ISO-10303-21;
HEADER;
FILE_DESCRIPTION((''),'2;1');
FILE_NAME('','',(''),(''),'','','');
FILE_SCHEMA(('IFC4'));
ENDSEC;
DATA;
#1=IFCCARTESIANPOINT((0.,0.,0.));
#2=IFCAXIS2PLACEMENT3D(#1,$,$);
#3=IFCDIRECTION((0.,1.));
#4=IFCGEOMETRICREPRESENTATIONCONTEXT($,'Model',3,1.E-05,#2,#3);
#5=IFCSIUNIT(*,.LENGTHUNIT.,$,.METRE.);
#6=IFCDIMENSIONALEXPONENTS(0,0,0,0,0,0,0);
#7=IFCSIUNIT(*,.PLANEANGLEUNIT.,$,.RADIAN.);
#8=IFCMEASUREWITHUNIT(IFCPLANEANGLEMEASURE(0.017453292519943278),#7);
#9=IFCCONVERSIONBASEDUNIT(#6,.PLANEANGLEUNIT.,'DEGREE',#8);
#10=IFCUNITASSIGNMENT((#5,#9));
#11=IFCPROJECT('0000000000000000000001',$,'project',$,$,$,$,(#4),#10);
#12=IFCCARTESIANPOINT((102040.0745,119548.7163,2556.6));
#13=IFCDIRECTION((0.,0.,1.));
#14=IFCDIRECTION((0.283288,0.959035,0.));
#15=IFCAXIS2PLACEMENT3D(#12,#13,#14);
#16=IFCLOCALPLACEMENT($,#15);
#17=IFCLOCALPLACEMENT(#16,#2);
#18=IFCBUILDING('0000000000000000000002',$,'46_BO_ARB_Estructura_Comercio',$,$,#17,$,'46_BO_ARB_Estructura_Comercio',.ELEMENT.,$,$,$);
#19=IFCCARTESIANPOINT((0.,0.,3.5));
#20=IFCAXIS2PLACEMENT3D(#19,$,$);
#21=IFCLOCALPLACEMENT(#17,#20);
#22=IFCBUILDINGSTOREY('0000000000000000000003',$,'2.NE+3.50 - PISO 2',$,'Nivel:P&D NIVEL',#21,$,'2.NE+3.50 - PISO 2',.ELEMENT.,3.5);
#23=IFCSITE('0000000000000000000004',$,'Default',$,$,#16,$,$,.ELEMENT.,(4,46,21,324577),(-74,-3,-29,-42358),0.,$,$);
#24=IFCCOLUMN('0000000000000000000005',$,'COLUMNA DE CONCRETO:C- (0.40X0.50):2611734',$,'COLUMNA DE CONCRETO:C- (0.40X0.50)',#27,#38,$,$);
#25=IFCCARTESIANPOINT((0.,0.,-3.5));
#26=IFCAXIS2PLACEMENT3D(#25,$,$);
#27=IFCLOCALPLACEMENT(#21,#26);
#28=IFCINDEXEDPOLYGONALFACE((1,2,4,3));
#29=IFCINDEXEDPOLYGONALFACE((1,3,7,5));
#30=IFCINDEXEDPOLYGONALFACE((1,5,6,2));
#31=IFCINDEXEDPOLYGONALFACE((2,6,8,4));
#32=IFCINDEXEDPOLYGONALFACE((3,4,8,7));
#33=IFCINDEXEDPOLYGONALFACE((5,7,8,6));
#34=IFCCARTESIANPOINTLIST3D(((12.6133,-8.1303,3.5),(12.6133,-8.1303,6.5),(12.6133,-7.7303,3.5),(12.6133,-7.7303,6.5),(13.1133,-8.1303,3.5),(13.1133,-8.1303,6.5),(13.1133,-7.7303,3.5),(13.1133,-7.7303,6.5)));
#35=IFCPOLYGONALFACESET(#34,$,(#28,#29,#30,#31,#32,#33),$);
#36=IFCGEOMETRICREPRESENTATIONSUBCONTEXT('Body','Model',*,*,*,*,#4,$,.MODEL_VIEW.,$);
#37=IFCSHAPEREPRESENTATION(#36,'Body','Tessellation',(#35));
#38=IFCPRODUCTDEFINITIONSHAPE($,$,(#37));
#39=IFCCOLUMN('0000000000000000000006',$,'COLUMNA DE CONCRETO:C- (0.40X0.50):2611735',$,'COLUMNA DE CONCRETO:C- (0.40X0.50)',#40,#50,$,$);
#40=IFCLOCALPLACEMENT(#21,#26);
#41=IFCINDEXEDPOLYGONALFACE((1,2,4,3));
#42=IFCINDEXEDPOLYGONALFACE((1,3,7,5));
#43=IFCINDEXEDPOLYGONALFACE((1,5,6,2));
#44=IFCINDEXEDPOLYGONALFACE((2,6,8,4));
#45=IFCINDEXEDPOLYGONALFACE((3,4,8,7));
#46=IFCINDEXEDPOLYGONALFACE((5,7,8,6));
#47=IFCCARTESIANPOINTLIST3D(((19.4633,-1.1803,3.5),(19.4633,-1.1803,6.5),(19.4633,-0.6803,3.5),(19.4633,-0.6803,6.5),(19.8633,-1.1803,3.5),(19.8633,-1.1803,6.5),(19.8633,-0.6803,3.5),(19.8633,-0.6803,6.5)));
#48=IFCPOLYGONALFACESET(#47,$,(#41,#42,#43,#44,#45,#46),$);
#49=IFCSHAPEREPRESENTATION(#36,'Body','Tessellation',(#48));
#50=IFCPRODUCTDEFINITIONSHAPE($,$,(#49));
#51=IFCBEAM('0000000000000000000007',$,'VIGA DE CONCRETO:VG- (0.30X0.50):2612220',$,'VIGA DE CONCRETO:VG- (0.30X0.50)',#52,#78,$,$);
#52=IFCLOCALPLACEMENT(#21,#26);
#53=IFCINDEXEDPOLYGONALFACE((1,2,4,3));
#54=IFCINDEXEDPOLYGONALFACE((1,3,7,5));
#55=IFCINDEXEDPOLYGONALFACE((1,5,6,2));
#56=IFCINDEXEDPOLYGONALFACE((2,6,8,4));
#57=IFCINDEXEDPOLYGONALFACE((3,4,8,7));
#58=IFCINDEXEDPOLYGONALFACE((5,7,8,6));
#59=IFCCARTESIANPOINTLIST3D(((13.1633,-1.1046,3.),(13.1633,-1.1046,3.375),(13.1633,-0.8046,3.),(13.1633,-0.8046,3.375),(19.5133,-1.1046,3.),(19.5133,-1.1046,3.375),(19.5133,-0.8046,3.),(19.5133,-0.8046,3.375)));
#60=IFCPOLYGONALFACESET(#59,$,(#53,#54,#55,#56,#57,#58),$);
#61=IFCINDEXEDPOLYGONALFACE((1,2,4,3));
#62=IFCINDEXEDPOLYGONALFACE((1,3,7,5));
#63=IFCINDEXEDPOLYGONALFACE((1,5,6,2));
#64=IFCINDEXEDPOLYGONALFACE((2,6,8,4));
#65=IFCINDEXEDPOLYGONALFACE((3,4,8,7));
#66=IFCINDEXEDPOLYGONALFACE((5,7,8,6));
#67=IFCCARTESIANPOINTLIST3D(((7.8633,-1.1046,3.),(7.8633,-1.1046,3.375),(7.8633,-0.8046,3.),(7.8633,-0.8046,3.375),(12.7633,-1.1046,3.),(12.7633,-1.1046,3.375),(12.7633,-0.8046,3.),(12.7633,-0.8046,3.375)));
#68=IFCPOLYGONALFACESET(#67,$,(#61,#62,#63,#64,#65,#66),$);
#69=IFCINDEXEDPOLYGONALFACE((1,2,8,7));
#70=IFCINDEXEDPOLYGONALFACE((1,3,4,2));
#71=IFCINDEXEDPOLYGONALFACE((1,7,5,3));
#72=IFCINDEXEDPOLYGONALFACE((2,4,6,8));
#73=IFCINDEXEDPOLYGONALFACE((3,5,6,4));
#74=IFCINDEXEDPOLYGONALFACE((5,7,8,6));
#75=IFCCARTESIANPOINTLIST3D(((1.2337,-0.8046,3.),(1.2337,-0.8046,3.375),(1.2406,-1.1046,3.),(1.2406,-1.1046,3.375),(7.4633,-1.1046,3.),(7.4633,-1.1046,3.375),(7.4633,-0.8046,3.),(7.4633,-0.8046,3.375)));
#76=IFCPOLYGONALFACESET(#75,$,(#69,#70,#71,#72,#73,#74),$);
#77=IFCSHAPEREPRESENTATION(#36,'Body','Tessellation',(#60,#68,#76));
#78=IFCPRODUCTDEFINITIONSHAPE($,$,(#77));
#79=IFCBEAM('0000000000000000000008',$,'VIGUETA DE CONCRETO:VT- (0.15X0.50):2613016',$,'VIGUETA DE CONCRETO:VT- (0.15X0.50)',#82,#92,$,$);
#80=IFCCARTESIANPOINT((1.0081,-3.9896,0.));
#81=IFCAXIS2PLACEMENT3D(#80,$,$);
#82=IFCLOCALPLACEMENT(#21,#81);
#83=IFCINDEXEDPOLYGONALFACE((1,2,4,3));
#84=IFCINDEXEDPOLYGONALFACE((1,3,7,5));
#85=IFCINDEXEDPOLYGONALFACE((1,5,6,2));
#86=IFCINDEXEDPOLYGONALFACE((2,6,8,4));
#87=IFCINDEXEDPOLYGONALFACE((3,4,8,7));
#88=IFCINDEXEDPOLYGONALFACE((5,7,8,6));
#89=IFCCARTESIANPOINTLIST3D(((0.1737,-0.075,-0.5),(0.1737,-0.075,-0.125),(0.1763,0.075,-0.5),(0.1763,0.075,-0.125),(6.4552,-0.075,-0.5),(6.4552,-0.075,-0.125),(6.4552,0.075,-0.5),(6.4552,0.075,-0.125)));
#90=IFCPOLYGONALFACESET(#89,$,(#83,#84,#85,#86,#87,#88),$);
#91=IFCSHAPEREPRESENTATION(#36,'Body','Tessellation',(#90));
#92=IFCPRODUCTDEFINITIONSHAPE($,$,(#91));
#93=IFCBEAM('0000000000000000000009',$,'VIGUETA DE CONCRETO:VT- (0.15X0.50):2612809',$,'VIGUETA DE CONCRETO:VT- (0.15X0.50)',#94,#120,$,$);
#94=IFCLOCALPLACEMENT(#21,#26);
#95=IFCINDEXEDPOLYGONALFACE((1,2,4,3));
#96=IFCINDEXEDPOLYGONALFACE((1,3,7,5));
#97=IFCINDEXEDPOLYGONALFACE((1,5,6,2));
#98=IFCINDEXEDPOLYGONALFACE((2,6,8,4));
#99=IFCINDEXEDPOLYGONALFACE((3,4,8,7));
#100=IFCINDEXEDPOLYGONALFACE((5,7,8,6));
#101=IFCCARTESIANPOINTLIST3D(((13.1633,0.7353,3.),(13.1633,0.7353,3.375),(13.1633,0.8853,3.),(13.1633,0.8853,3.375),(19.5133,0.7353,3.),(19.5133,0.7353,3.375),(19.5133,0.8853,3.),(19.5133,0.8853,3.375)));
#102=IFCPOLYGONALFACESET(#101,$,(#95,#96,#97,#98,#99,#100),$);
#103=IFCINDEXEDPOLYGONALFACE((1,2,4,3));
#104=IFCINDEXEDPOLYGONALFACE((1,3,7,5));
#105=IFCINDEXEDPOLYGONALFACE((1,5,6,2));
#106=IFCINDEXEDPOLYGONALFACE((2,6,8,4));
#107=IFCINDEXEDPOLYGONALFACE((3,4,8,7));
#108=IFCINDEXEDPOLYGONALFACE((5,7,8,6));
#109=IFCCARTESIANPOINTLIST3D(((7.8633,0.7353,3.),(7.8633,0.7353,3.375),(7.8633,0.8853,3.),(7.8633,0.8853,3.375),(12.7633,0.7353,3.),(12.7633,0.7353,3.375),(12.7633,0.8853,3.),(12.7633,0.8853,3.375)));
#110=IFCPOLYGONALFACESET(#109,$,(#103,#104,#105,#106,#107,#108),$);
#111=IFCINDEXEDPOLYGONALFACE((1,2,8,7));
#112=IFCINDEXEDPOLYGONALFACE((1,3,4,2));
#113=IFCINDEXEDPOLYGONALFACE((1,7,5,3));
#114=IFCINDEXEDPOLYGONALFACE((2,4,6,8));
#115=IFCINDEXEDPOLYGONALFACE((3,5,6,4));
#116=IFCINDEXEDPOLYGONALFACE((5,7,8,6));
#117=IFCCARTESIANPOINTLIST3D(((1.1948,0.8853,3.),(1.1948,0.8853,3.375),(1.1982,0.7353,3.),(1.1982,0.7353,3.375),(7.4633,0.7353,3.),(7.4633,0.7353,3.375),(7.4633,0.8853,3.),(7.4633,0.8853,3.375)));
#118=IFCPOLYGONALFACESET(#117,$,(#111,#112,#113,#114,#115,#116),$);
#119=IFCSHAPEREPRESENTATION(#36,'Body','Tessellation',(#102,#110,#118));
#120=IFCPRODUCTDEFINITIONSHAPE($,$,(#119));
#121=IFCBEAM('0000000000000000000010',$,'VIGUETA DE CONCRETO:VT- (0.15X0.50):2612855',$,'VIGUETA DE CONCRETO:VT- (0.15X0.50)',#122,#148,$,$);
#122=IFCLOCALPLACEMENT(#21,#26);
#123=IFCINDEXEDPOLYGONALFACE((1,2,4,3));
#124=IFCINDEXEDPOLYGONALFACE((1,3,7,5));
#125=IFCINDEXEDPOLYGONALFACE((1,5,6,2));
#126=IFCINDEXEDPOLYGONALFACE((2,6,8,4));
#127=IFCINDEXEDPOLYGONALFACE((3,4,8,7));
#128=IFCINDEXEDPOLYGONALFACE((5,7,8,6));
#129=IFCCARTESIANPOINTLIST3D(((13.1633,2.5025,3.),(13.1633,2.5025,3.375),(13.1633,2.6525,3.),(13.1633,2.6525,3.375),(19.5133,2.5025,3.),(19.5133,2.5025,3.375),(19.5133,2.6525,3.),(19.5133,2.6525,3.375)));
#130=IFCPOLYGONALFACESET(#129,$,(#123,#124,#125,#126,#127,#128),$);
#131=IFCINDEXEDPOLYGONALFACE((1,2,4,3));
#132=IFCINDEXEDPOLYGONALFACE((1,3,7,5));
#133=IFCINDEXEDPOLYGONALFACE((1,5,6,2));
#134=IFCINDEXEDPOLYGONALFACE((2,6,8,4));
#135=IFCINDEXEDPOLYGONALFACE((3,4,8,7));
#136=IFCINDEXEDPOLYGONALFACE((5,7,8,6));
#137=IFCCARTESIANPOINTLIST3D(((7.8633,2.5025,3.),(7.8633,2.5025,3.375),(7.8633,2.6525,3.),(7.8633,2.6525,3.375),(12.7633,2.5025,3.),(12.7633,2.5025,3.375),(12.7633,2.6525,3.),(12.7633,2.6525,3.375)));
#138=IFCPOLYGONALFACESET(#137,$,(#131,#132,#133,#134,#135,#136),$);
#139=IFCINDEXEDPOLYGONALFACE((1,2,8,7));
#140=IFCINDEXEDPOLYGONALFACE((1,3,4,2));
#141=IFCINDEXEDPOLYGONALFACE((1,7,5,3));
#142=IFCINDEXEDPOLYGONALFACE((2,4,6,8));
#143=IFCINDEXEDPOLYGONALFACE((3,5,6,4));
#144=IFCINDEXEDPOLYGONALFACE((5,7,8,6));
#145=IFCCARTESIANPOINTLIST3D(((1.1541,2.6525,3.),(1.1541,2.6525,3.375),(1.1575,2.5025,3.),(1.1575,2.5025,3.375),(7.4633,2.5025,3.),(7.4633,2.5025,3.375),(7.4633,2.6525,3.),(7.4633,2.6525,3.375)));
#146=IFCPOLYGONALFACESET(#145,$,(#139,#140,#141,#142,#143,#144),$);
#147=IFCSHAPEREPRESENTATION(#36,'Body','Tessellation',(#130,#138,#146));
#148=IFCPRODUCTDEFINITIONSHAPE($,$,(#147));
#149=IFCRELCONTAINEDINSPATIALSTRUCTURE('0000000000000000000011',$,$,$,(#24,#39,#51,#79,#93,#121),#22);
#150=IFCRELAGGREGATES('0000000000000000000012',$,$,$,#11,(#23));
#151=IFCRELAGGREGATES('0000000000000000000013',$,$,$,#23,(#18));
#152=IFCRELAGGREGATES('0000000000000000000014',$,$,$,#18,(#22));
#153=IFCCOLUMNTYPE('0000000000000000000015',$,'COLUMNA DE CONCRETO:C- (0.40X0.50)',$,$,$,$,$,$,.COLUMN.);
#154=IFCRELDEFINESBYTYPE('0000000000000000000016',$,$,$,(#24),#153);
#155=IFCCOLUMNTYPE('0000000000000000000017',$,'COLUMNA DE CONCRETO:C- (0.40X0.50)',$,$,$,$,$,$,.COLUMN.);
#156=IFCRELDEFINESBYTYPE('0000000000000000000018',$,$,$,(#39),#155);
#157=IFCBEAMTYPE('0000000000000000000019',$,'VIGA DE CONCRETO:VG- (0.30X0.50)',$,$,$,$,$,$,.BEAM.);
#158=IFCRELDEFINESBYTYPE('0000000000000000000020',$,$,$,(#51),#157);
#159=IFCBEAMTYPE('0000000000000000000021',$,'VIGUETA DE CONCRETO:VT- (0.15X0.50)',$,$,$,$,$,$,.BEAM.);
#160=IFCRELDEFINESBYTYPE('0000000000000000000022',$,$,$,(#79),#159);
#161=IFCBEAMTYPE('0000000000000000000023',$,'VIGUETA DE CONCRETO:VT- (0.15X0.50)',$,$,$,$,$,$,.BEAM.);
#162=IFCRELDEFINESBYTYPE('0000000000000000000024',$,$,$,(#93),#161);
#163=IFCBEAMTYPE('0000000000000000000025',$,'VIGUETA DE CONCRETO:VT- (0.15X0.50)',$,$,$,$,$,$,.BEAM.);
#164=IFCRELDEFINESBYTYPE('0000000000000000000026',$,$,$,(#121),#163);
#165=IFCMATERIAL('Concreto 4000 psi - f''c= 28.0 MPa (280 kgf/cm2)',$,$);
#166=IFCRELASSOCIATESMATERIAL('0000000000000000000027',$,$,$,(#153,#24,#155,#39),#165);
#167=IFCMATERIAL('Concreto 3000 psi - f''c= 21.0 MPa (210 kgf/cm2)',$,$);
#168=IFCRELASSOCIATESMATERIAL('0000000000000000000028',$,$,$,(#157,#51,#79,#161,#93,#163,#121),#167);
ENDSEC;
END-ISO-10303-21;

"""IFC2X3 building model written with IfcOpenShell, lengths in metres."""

from ifc_helpers import new_model, entity, si_unit, converted_unit, direction, frame, frame_2d, origin, place, context, subcontext, project, spatial, rectangle, extrude, clip, halfspace, source, transform, mapped, material, type_object, type_shapes, element, save


model = new_model("IFC2X3")

# Units and contexts
model_context = context("Model", 3, precision=1e-05, world=origin(), true_north=direction((0.0, 1.0)))
body_context = subcontext(model_context, "Body", "Model", "MODEL_VIEW")
ifc_project = project(units=[si_unit("LENGTHUNIT", "METRE"), converted_unit("PLANEANGLEUNIT", "DEGREE", entity("IfcPlaneAngleMeasure", 0.017453292519943278), si_unit("PLANEANGLEUNIT", "RADIAN"), dimensions=[0, 0, 0, 0, 0, 0, 0])], contexts=[model_context])

# Site, building, storey
site_placement = place(None, frame((102040.0745, 119548.7163, 2556.6), z_axis=(0.0, 0.0, 1.0), x_axis=(0.283288, 0.959035, 0.0)))
site = spatial("IfcSite", under=ifc_project, at=site_placement, Name="Default", CompositionType="ELEMENT", RefLatitude=(4, 46, 21, 324577), RefLongitude=(-74, -3, -29, -42358), RefElevation=0.0)
building_placement = place(site_placement, origin())
building = spatial("IfcBuilding", under=site, at=building_placement, Name="46_BO_ARB_Estructura_Comercio", LongName="46_BO_ARB_Estructura_Comercio", CompositionType="ELEMENT")
storey_placement = place(building_placement, frame((0.0, 0.0, 3.5)))
storey = spatial("IfcBuildingStorey", under=building, at=storey_placement, Name="2.NE+3.50 - PISO 2", ObjectType="Nivel:P&D NIVEL", LongName="2.NE+3.50 - PISO 2", CompositionType="ELEMENT", Elevation=3.5)

# Columns
ifc_material_1 = material(Name="Concreto 4000 psi - f'c= 28.0 MPa (280 kgf/cm2)")
column_type_1 = type_object("IfcColumnType", Name="COLUMNA DE CONCRETO:C- (0.40X0.50)", PredefinedType="COLUMN", material=ifc_material_1)
shared_shape_1 = source(origin(), body_context, "Body", "SweptSolid", [
    extrude(rectangle(XDim=0.4, YDim=0.5, at=frame_2d((0.0, 0.0), x_axis=(1.0, 0.0))), frame((12.8633, -7.9303, 3.5), z_axis=(0.0, 0.0, 1.0), x_axis=(0.0, -1.0, 0.0)), (0.0, 0.0, 1.0), 3.0),
])
type_shapes(column_type_1, [shared_shape_1])
column_1_placement = place(storey_placement, frame((0.0, 0.0, -3.5)))
element("IfcColumn", 1, at=column_1_placement, inside=storey, type_object=column_type_1, material=ifc_material_1, Name="COLUMNA DE CONCRETO:C- (0.40X0.50):2611734", ObjectType="COLUMNA DE CONCRETO:C- (0.40X0.50)", context=body_context, shape_type="MappedRepresentation", body=[
    mapped(shared_shape_1, transform((0.0, 0.0, 0.0), scale=1.0)),
])
column_type_2 = type_object("IfcColumnType", Name="COLUMNA DE CONCRETO:C- (0.40X0.50)", PredefinedType="COLUMN", material=ifc_material_1)
shared_shape_2 = source(origin(), body_context, "Body", "SweptSolid", [
    extrude(rectangle(XDim=0.5, YDim=0.4, at=frame_2d((0.0, 0.0), x_axis=(1.0, 0.0))), frame((19.6633, -0.9303, 3.5), z_axis=(0.0, 0.0, 1.0), x_axis=(0.0, -1.0, 0.0)), (0.0, 0.0, 1.0), 3.0),
])
type_shapes(column_type_2, [shared_shape_2])
column_2_placement = place(storey_placement, frame((0.0, 0.0, -3.5)))
element("IfcColumn", 2, at=column_2_placement, inside=storey, type_object=column_type_2, material=ifc_material_1, Name="COLUMNA DE CONCRETO:C- (0.40X0.50):2611735", ObjectType="COLUMNA DE CONCRETO:C- (0.40X0.50)", context=body_context, shape_type="MappedRepresentation", body=[
    mapped(shared_shape_2, transform((0.0, 0.0, 0.0), scale=1.0)),
])

# Beams
ifc_material_2 = material(Name="Concreto 3000 psi - f'c= 21.0 MPa (210 kgf/cm2)")
beam_type_1 = type_object("IfcBeamType", Name="VIGA DE CONCRETO:VG- (0.30X0.50)", PredefinedType="BEAM", material=ifc_material_2)
shared_shape_3 = source(origin(), body_context, "Body", "SweptSolid", [
    extrude(rectangle(XDim=0.375, YDim=0.3, at=frame_2d((0.0, 0.0), x_axis=(1.0, 0.0))), frame((13.1633, -0.9546, 3.1875), z_axis=(1.0, 0.0, 0.0), x_axis=(0.0, 0.0, -1.0)), (0.0, 0.0, 1.0), 6.35),
    extrude(rectangle(XDim=0.375, YDim=0.3, at=frame_2d((0.0, 0.0), x_axis=(1.0, 0.0))), frame((7.8633, -0.9546, 3.1875), z_axis=(1.0, 0.0, 0.0), x_axis=(0.0, 0.0, -1.0)), (0.0, 0.0, 1.0), 4.9),
    clip(extrude(rectangle(XDim=0.375, YDim=0.3, at=frame_2d((0.0, 0.0), x_axis=(1.0, 0.0))), frame((1.2337, -0.9546, 3.1875), z_axis=(1.0, 0.0, 0.0), x_axis=(0.0, 0.0, -1.0)), (0.0, 0.0, 1.0), 6.2296), halfspace(frame((1.1171, 4.257, 3.5), z_axis=(-0.999735, -0.023028, 0.0), x_axis=(0.023028, -0.999735, 0.0)), False)),
])
type_shapes(beam_type_1, [shared_shape_3])
beam_1_placement = place(storey_placement, frame((0.0, 0.0, -3.5)))
element("IfcBeam", 3, at=beam_1_placement, inside=storey, type_object=beam_type_1, material=ifc_material_2, Name="VIGA DE CONCRETO:VG- (0.30X0.50):2612220", ObjectType="VIGA DE CONCRETO:VG- (0.30X0.50)", context=body_context, shape_type="MappedRepresentation", body=[
    mapped(shared_shape_3, transform((0.0, 0.0, 0.0), scale=1.0)),
])
beam_type_2 = type_object("IfcBeamType", Name="VIGUETA DE CONCRETO:VT- (0.15X0.50)", PredefinedType="BEAM")
beam_2_placement = place(storey_placement, frame((1.0081, -3.9896, 0.0)))
element("IfcBeam", 4, at=beam_2_placement, inside=storey, type_object=beam_type_2, material=ifc_material_2, Name="VIGUETA DE CONCRETO:VT- (0.15X0.50):2613016", ObjectType="VIGUETA DE CONCRETO:VT- (0.15X0.50)", context=body_context, shape_type="SweptSolid", body=[
    clip(extrude(rectangle(XDim=0.375, YDim=0.15, at=frame_2d((0.0, 0.0), x_axis=(1.0, 0.0))), frame((0.1737, 0.0, -0.3125), z_axis=(1.0, 0.0, 0.0), x_axis=(0.0, 0.0, -1.0)), (0.0, 0.0, 1.0), 6.2815), halfspace(frame((0.2277, 3.0122, 0.0), z_axis=(-0.999847, 0.017477, 0.0), x_axis=(-0.017477, -0.999847, 0.0)), False)),
])
beam_type_3 = type_object("IfcBeamType", Name="VIGUETA DE CONCRETO:VT- (0.15X0.50)", PredefinedType="BEAM", material=ifc_material_2)
shared_shape_4 = source(origin(), body_context, "Body", "SweptSolid", [
    extrude(rectangle(XDim=0.375, YDim=0.15, at=frame_2d((0.0, 0.0), x_axis=(1.0, 0.0))), frame((13.1633, 0.8103, 3.1875), z_axis=(1.0, 0.0, 0.0), x_axis=(0.0, 0.0, -1.0)), (0.0, 0.0, 1.0), 6.35),
    extrude(rectangle(XDim=0.375, YDim=0.15, at=frame_2d((0.0, 0.0), x_axis=(1.0, 0.0))), frame((7.8633, 0.8103, 3.1875), z_axis=(1.0, 0.0, 0.0), x_axis=(0.0, 0.0, -1.0)), (0.0, 0.0, 1.0), 4.9),
    clip(extrude(rectangle(XDim=0.375, YDim=0.15, at=frame_2d((0.0, 0.0), x_axis=(1.0, 0.0))), frame((1.1948, 0.8103, 3.1875), z_axis=(1.0, 0.0, 0.0), x_axis=(0.0, 0.0, -1.0)), (0.0, 0.0, 1.0), 6.2685), halfspace(frame((1.1171, 4.257, 3.5), z_axis=(-0.999735, -0.023028, 0.0), x_axis=(0.023028, -0.999735, 0.0)), False)),
])
type_shapes(beam_type_3, [shared_shape_4])
beam_3_placement = place(storey_placement, frame((0.0, 0.0, -3.5)))
element("IfcBeam", 5, at=beam_3_placement, inside=storey, type_object=beam_type_3, material=ifc_material_2, Name="VIGUETA DE CONCRETO:VT- (0.15X0.50):2612809", ObjectType="VIGUETA DE CONCRETO:VT- (0.15X0.50)", context=body_context, shape_type="MappedRepresentation", body=[
    mapped(shared_shape_4, transform((0.0, 0.0, 0.0), scale=1.0)),
])
beam_type_4 = type_object("IfcBeamType", Name="VIGUETA DE CONCRETO:VT- (0.15X0.50)", PredefinedType="BEAM", material=ifc_material_2)
shared_shape_5 = source(origin(), body_context, "Body", "SweptSolid", [
    extrude(rectangle(XDim=0.375, YDim=0.15, at=frame_2d((0.0, 0.0), x_axis=(1.0, 0.0))), frame((13.1633, 2.5775, 3.1875), z_axis=(1.0, 0.0, 0.0), x_axis=(0.0, 0.0, -1.0)), (0.0, 0.0, 1.0), 6.35),
    extrude(rectangle(XDim=0.375, YDim=0.15, at=frame_2d((0.0, 0.0), x_axis=(1.0, 0.0))), frame((7.8633, 2.5775, 3.1875), z_axis=(1.0, 0.0, 0.0), x_axis=(0.0, 0.0, -1.0)), (0.0, 0.0, 1.0), 4.9),
    clip(extrude(rectangle(XDim=0.375, YDim=0.15, at=frame_2d((0.0, 0.0), x_axis=(1.0, 0.0))), frame((1.1541, 2.5775, 3.1875), z_axis=(1.0, 0.0, 0.0), x_axis=(0.0, 0.0, -1.0)), (0.0, 0.0, 1.0), 6.3092), halfspace(frame((1.1171, 4.257, 3.5), z_axis=(-0.999735, -0.023028, 0.0), x_axis=(0.023028, -0.999735, 0.0)), False)),
])
type_shapes(beam_type_4, [shared_shape_5])
beam_4_placement = place(storey_placement, frame((0.0, 0.0, -3.5)))
element("IfcBeam", 6, at=beam_4_placement, inside=storey, type_object=beam_type_4, material=ifc_material_2, Name="VIGUETA DE CONCRETO:VT- (0.15X0.50):2612855", ObjectType="VIGUETA DE CONCRETO:VT- (0.15X0.50)", context=body_context, shape_type="MappedRepresentation", body=[
    mapped(shared_shape_5, transform((0.0, 0.0, 0.0), scale=1.0)),
])

save(model, "model.ifc")
